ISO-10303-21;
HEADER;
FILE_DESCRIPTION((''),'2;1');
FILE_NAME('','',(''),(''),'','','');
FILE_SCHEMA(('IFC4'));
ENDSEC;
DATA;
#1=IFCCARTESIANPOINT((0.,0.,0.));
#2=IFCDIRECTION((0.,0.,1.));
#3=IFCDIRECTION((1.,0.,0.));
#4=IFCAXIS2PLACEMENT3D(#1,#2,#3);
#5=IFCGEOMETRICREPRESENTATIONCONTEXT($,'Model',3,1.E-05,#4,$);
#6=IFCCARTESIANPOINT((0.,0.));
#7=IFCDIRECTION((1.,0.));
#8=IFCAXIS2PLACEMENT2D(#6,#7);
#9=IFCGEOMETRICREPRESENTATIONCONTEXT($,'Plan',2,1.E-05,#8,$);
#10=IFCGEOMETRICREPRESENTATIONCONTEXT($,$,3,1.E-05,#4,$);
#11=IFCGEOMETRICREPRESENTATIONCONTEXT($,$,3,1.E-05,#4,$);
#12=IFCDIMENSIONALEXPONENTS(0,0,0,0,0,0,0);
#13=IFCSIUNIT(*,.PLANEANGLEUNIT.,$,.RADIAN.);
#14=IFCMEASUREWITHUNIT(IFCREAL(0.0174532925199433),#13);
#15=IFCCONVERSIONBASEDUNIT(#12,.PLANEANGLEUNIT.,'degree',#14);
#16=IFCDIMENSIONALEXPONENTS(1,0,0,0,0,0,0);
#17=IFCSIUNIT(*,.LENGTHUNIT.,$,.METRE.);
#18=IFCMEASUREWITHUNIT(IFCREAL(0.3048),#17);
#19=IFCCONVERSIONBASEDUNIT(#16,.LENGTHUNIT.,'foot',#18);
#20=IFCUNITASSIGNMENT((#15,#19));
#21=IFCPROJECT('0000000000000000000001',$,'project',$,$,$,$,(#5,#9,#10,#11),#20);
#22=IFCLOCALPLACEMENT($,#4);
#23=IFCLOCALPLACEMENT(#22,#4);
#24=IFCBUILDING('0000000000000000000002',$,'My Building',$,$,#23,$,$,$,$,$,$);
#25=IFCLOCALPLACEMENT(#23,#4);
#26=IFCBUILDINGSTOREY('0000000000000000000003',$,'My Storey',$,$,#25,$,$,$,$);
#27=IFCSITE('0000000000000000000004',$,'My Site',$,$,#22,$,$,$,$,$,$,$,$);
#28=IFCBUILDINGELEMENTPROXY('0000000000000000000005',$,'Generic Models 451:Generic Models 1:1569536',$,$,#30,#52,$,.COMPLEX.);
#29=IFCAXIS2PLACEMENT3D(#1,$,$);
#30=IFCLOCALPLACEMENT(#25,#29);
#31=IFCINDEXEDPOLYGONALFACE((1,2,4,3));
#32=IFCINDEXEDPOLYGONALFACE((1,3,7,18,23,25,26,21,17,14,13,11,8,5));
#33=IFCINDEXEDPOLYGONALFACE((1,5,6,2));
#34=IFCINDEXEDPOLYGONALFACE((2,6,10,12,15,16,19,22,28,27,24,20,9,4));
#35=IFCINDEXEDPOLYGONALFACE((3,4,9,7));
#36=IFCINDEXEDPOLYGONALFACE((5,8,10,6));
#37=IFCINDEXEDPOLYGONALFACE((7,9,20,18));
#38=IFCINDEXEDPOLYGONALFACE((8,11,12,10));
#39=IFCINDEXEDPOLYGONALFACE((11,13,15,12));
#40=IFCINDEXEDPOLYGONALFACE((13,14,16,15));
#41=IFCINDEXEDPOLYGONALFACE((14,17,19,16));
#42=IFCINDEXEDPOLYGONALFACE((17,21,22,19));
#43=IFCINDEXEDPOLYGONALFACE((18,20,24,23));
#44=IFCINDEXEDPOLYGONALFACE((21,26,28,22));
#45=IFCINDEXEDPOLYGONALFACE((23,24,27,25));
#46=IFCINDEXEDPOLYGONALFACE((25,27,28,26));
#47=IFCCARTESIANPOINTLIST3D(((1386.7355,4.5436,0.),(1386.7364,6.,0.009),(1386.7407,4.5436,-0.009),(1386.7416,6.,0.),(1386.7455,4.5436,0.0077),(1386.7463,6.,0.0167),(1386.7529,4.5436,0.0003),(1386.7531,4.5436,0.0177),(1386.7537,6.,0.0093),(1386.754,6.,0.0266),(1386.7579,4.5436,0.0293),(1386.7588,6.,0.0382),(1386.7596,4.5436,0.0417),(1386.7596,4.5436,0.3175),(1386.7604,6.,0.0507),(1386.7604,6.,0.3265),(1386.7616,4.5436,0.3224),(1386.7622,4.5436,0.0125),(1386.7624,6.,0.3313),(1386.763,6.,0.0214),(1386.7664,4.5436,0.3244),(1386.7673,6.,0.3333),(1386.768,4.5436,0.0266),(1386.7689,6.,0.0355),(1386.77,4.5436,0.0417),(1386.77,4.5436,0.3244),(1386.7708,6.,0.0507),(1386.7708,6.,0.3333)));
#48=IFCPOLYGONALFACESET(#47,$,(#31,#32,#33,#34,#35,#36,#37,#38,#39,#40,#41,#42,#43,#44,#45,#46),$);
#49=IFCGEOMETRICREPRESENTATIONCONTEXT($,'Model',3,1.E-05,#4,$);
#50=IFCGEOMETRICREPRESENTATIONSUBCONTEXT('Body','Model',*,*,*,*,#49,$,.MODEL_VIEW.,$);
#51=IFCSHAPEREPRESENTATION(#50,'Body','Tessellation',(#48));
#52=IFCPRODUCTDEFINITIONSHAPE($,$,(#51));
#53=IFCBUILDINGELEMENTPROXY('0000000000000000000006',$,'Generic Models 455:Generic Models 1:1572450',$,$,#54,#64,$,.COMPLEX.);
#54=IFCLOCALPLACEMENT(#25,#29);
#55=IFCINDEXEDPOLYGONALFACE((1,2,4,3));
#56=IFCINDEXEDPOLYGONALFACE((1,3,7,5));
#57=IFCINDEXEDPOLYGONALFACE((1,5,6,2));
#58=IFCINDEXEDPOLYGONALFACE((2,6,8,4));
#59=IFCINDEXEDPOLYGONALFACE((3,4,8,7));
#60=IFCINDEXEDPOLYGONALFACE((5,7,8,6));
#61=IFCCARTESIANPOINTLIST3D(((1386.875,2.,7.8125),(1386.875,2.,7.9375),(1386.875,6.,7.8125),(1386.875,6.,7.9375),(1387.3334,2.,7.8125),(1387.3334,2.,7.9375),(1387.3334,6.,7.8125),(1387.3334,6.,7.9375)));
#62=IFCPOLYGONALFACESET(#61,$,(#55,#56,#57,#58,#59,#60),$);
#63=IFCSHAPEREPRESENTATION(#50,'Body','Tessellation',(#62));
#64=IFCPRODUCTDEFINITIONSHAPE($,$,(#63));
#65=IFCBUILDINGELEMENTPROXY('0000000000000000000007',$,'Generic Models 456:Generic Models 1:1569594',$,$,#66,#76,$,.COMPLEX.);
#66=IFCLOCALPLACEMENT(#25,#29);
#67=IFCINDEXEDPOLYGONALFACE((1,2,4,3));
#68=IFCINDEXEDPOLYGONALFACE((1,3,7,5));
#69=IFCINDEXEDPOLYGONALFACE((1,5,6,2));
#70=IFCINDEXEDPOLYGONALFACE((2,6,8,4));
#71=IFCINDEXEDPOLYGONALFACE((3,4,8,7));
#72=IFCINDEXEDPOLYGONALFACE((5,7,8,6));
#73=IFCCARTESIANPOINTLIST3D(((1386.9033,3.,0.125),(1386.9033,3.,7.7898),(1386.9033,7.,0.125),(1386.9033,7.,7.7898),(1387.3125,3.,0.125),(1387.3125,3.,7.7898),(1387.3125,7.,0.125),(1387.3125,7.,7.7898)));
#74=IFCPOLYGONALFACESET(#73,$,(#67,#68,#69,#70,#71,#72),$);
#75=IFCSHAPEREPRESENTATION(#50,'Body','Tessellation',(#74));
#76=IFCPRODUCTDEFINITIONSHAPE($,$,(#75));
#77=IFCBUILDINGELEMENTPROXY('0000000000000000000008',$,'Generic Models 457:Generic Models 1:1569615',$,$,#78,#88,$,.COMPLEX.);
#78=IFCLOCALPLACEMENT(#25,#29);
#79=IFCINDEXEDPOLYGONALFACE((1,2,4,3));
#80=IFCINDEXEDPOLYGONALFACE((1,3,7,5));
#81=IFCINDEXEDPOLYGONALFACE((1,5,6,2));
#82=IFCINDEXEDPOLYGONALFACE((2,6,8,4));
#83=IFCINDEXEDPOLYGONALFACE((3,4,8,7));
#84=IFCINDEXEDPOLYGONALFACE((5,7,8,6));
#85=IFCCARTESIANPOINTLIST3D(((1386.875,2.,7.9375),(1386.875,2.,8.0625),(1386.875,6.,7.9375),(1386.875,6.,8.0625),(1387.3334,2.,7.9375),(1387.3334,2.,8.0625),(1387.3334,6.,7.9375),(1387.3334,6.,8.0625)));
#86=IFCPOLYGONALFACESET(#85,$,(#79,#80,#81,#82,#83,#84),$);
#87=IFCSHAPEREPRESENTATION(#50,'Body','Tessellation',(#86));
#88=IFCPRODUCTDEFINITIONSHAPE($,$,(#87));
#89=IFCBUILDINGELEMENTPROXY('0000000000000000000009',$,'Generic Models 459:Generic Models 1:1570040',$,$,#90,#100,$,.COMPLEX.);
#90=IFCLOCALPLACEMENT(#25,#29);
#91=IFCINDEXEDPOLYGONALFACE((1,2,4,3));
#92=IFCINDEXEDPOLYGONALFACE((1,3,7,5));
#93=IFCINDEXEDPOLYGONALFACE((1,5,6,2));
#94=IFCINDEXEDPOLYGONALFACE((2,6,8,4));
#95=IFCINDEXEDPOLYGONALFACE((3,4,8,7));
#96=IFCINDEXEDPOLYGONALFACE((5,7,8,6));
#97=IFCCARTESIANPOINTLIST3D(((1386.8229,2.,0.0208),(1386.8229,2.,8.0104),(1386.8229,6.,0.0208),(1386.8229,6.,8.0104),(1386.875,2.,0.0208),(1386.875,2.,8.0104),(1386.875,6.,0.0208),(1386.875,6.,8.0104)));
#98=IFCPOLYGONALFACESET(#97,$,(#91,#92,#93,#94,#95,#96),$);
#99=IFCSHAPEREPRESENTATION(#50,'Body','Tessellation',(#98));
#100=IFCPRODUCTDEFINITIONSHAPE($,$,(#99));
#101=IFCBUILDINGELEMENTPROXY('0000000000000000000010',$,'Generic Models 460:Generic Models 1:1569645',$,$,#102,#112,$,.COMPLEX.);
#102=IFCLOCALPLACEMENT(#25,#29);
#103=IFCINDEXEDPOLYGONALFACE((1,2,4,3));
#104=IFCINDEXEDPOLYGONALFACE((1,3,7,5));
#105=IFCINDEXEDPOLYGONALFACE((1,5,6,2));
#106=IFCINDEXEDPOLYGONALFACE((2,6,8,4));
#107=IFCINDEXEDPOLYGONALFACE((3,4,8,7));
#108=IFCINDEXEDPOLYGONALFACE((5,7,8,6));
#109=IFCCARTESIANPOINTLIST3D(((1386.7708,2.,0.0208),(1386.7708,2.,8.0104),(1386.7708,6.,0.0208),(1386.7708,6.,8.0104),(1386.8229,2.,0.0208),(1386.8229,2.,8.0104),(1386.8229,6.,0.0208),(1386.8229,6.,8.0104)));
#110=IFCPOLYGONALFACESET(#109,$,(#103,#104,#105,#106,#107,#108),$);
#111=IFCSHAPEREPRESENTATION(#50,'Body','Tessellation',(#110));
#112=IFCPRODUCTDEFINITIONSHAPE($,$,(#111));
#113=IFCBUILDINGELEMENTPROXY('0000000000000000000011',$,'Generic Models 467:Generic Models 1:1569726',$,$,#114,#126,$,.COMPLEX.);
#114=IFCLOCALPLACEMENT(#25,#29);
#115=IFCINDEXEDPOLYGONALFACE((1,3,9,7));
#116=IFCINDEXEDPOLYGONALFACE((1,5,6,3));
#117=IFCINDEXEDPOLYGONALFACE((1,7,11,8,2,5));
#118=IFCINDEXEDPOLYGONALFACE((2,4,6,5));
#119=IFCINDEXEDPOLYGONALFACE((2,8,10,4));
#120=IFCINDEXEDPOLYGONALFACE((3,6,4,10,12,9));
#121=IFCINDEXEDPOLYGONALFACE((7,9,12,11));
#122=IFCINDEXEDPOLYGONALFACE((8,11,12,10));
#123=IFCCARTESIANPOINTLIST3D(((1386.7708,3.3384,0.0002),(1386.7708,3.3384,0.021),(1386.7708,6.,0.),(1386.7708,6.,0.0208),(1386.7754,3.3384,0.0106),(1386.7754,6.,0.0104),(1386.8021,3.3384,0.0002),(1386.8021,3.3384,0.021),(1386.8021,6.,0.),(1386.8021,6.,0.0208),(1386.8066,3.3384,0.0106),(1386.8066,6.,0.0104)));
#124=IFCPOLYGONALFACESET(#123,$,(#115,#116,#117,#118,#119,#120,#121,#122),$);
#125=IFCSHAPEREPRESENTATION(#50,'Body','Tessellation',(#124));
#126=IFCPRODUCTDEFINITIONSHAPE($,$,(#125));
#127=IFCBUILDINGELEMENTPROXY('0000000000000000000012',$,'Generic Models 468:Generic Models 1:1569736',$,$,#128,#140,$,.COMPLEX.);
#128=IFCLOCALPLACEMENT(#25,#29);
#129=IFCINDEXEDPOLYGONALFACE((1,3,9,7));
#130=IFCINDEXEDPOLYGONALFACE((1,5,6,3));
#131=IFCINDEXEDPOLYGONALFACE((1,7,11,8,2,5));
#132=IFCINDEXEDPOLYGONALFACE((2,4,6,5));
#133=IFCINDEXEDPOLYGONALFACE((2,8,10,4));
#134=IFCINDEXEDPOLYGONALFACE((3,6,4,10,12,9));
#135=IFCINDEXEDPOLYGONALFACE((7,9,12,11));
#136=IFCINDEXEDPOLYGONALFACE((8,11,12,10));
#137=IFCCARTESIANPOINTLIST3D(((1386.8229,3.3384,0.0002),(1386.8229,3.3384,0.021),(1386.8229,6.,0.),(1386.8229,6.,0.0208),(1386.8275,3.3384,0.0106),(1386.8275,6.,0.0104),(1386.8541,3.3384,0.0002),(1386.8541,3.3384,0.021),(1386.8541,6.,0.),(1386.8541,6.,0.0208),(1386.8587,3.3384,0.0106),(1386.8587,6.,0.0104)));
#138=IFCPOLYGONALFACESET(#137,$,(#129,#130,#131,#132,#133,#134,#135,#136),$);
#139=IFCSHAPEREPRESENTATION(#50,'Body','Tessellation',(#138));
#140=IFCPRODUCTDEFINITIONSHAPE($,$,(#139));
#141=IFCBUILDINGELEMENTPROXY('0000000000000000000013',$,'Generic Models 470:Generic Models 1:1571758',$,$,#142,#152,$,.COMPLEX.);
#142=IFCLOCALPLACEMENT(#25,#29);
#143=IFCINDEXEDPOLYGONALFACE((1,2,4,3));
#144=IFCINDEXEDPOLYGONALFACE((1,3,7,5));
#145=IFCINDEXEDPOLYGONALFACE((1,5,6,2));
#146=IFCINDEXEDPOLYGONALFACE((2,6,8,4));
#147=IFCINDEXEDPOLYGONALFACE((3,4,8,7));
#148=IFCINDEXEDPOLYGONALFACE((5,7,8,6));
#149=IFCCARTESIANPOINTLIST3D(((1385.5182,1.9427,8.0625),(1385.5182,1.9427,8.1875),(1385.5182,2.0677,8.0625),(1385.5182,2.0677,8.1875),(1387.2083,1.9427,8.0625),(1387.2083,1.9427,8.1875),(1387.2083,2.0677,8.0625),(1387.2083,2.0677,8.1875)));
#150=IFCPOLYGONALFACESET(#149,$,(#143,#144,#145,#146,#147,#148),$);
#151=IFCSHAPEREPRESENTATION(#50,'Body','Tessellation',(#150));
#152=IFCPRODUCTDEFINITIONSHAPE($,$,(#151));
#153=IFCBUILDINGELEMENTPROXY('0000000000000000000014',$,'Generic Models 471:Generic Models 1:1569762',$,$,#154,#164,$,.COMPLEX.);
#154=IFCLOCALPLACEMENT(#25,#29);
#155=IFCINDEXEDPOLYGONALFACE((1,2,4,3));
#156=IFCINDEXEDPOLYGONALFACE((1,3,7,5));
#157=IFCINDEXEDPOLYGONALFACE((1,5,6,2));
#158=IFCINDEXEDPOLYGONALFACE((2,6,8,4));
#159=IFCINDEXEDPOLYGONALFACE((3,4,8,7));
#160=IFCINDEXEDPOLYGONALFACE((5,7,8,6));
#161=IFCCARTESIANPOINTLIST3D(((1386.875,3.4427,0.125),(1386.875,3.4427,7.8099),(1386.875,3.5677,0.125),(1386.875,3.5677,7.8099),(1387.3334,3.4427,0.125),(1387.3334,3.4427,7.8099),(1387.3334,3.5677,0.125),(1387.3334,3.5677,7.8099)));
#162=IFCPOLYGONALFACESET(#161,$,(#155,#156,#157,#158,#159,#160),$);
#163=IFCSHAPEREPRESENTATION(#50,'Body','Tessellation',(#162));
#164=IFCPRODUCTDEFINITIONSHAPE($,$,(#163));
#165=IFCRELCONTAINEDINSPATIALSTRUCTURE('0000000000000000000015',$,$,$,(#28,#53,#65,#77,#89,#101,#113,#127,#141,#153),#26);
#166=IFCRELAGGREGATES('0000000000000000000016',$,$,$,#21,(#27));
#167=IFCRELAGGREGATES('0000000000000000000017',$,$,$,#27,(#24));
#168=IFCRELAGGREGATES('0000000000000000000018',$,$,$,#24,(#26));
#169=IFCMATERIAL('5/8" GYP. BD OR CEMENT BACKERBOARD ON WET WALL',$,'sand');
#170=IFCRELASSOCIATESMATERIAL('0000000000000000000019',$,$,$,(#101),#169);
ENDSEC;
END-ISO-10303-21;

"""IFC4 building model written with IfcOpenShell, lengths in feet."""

from ifc_helpers import new_model, entity, si_unit, converted_unit, frame, origin_with_axes, origin_2d_with_axis, place, context, subcontext, project, spatial, polyline, outline, extrude, material, element, save


model = new_model("IFC4")

# Units and contexts
model_context_1 = context("Model", 3, precision=1e-05, world=origin_with_axes())
plan_context = context("Plan", 2, precision=1e-05, world=origin_2d_with_axis())
model_context_2 = context("Model", 3, precision=1e-05, world=origin_with_axes())
context_of_model_1 = context(None, 3, precision=1e-05, world=origin_with_axes())
context_of_model_2 = context(None, 3, precision=1e-05, world=origin_with_axes())
body_context = subcontext(model_context_2, "Body", "Model", "MODEL_VIEW")
ifc_project = project(units=[converted_unit("PLANEANGLEUNIT", "degree", entity("IfcReal", 0.0174532925199433), si_unit("PLANEANGLEUNIT", "RADIAN"), dimensions=[0, 0, 0, 0, 0, 0, 0]), converted_unit("LENGTHUNIT", "foot", entity("IfcReal", 0.3048), si_unit("LENGTHUNIT", "METRE"), dimensions=[1, 0, 0, 0, 0, 0, 0])], contexts=[model_context_1, plan_context, context_of_model_1, context_of_model_2])

# Site, building, storey
site_placement = place(None, origin_with_axes())
site = spatial("IfcSite", under=ifc_project, at=site_placement, Name="My Site")
building_placement = place(site_placement, origin_with_axes())
building = spatial("IfcBuilding", under=site, at=building_placement, Name="My Building")
storey_placement = place(building_placement, origin_with_axes())
storey = spatial("IfcBuildingStorey", under=building, at=storey_placement, Name="My Storey")

# Building element proxies
ifc_material_1 = material(Name="5/8\" GYP. BD OR CEMENT BACKERBOARD ON WET WALL", Category="sand")
proxy_1_placement = place(storey_placement, frame((1386.7364, 6.0, 0.0), z_axis=(0.0, -1.0, 0.0), x_axis=(0.0, 0.0, 1.0)))
element("IfcBuildingElementProxy", 1, at=proxy_1_placement, inside=storey, Name="Generic Models 451:Generic Models 1:1569536", PredefinedType="COMPLEX", context=body_context, shape_type="SweptSolid", body=[
    extrude(outline(polyline([(0.0748, 0.0), (0.0624, -0.0017), (-0.2134, -0.0039), (-0.2182, -0.0059), (-0.2202, -0.0108), (-0.2202, -0.0144), (0.0625, -0.0122), (0.0776, -0.01), (0.0917, -0.0041), (0.1037, 0.0053), (0.1129, 0.0175), (0.1039, 0.0226), (0.0963, 0.0126), (0.0864, 0.0049), (0.0748, 0.0)])), frame((0.113, -0.0218, 0.0), z_axis=(0.0, 0.0, -1.0), x_axis=(-0.99997, -0.007803, 0.0)), (0.006156, 0.000628, -0.999981), 1.4564),
])
proxy_2_placement = place(storey_placement, frame((1386.875, 6.0, 7.8125), z_axis=(0.0, -1.0, 0.0), x_axis=(0.0, 0.0, 1.0)))
element("IfcBuildingElementProxy", 2, at=proxy_2_placement, inside=storey, Name="Generic Models 455:Generic Models 1:1572450", PredefinedType="COMPLEX", context=body_context, shape_type="SweptSolid", body=[
    extrude(outline(polyline([(-0.2292, -0.0625), (0.2292, -0.0625), (0.2292, 0.0625), (-0.2292, 0.0625), (-0.2292, -0.0625)])), frame((0.0625, -0.2292, 0.0), z_axis=(0.0, 0.0, -1.0), x_axis=(0.0, 1.0, 0.0)), (0.0, 0.0, -1.0), 4.0),
])
proxy_3_placement = place(storey_placement, frame((1386.9033, 7.0, 0.125), z_axis=(0.0, -1.0, 0.0), x_axis=(0.0, 0.0, 1.0)))
element("IfcBuildingElementProxy", 3, at=proxy_3_placement, inside=storey, Name="Generic Models 456:Generic Models 1:1569594", PredefinedType="COMPLEX", context=body_context, shape_type="SweptSolid", body=[
    extrude(outline(polyline([(-0.2046, -3.8324), (0.2046, -3.8324), (0.2046, 3.8324), (-0.2046, 3.8324), (-0.2046, -3.8324)])), frame((3.8324, -0.2046, 0.0), z_axis=(0.0, 0.0, -1.0), x_axis=(0.0, 1.0, 0.0)), (0.0, 0.0, -1.0), 4.0),
])
proxy_4_placement = place(storey_placement, frame((1386.875, 6.0, 7.9375), z_axis=(0.0, -1.0, 0.0), x_axis=(0.0, 0.0, 1.0)))
element("IfcBuildingElementProxy", 4, at=proxy_4_placement, inside=storey, Name="Generic Models 457:Generic Models 1:1569615", PredefinedType="COMPLEX", context=body_context, shape_type="SweptSolid", body=[
    extrude(outline(polyline([(-0.2292, -0.0625), (0.2292, -0.0625), (0.2292, 0.0625), (-0.2292, 0.0625), (-0.2292, -0.0625)])), frame((0.0625, -0.2292, 0.0), z_axis=(0.0, 0.0, -1.0), x_axis=(0.0, 1.0, 0.0)), (0.0, 0.0, -1.0), 4.0),
])
proxy_5_placement = place(storey_placement, frame((1386.8229, 6.0, 0.0208), z_axis=(0.0, -1.0, 0.0), x_axis=(0.0, 0.0, 1.0)))
element("IfcBuildingElementProxy", 5, at=proxy_5_placement, inside=storey, Name="Generic Models 459:Generic Models 1:1570040", PredefinedType="COMPLEX", context=body_context, shape_type="SweptSolid", body=[
    extrude(outline(polyline([(-3.9948, -0.026), (3.9948, -0.026), (3.9948, 0.026), (-3.9948, 0.026), (-3.9948, -0.026)])), frame((3.9948, -0.026, 0.0), z_axis=(0.0, 0.0, -1.0), x_axis=(-1.0, 0.0, 0.0)), (0.0, 0.0, -1.0), 4.0),
])
proxy_6_placement = place(storey_placement, frame((1386.7708, 6.0, 0.0208), z_axis=(0.0, -1.0, 0.0), x_axis=(0.0, 0.0, 1.0)))
element("IfcBuildingElementProxy", 6, at=proxy_6_placement, inside=storey, material=ifc_material_1, Name="Generic Models 460:Generic Models 1:1569645", PredefinedType="COMPLEX", context=body_context, shape_type="SweptSolid", body=[
    extrude(outline(polyline([(-3.9948, -0.026), (3.9948, -0.026), (3.9948, 0.026), (-3.9948, 0.026), (-3.9948, -0.026)])), frame((3.9948, -0.026, 0.0), z_axis=(0.0, 0.0, -1.0), x_axis=(1.0, 0.0, 0.0)), (0.0, 0.0, -1.0), 4.0),
])
for number, where, z_axis, x_axis, name in (
    (7, (1386.7708, 6.0, 0.0), (0.0, -1.0, 0.0), (0.0, 0.0, 1.0), "Generic Models 467:Generic Models 1:1569726"),
    (8, (1386.8229, 6.0, 0.0), (0.0, -1.0, 0.0), (0.0, 0.0, 1.0), "Generic Models 468:Generic Models 1:1569736"),
):
    element("IfcBuildingElementProxy", number, at=place(storey_placement, frame(where, z_axis=z_axis, x_axis=x_axis)), inside=storey, Name=name, PredefinedType="COMPLEX", context=body_context, shape_type="SweptSolid", body=[
        extrude(outline(polyline([(0.0201, 0.0), (-0.0066, 0.0162), (-0.016, 0.0097), (-0.0175, -0.0016), (0.0093, -0.0178), (0.0107, -0.0065), (0.0201, 0.0)])), frame((0.0104, -0.0172, 0.0), z_axis=(0.0, 0.0, -1.0), x_axis=(0.51911, 0.854708, 0.0)), (0.000035, 0.000056, -1.0), 2.6616),
    ])
proxy_7_placement = place(storey_placement, frame((1385.5182, 1.9427, 8.0625), z_axis=(1.0, 0.0, 0.0), x_axis=(0.0, 0.0, -1.0)))
element("IfcBuildingElementProxy", 9, at=proxy_7_placement, inside=storey, Name="Generic Models 470:Generic Models 1:1571758", PredefinedType="COMPLEX", context=body_context, shape_type="SweptSolid", body=[
    extrude(outline(polyline([(-0.0625, -0.0625), (0.0625, -0.0625), (0.0625, 0.0625), (-0.0625, 0.0625), (-0.0625, -0.0625)])), frame((-0.0625, 0.0625, 0.0), z_axis=(0.0, 0.0, -1.0), x_axis=(1.0, 0.0, 0.0)), (0.0, 0.0, -1.0), 1.6902),
])
proxy_8_placement = place(storey_placement, frame((1386.875, 3.4427, 0.125), z_axis=(0.0, 0.0, 1.0), x_axis=(1.0, 0.0, 0.0)))
element("IfcBuildingElementProxy", 10, at=proxy_8_placement, inside=storey, Name="Generic Models 471:Generic Models 1:1569762", PredefinedType="COMPLEX", context=body_context, shape_type="SweptSolid", body=[
    extrude(outline(polyline([(-0.2292, -0.0625), (0.2292, -0.0625), (0.2292, 0.0625), (-0.2292, 0.0625), (-0.2292, -0.0625)])), frame((0.2292, 0.0625, 0.0), z_axis=(0.0, 0.0, -1.0), x_axis=(-1.0, 0.0, 0.0)), (0.0, 0.0, -1.0), 7.6849),
])

save(model, "model.ifc")
